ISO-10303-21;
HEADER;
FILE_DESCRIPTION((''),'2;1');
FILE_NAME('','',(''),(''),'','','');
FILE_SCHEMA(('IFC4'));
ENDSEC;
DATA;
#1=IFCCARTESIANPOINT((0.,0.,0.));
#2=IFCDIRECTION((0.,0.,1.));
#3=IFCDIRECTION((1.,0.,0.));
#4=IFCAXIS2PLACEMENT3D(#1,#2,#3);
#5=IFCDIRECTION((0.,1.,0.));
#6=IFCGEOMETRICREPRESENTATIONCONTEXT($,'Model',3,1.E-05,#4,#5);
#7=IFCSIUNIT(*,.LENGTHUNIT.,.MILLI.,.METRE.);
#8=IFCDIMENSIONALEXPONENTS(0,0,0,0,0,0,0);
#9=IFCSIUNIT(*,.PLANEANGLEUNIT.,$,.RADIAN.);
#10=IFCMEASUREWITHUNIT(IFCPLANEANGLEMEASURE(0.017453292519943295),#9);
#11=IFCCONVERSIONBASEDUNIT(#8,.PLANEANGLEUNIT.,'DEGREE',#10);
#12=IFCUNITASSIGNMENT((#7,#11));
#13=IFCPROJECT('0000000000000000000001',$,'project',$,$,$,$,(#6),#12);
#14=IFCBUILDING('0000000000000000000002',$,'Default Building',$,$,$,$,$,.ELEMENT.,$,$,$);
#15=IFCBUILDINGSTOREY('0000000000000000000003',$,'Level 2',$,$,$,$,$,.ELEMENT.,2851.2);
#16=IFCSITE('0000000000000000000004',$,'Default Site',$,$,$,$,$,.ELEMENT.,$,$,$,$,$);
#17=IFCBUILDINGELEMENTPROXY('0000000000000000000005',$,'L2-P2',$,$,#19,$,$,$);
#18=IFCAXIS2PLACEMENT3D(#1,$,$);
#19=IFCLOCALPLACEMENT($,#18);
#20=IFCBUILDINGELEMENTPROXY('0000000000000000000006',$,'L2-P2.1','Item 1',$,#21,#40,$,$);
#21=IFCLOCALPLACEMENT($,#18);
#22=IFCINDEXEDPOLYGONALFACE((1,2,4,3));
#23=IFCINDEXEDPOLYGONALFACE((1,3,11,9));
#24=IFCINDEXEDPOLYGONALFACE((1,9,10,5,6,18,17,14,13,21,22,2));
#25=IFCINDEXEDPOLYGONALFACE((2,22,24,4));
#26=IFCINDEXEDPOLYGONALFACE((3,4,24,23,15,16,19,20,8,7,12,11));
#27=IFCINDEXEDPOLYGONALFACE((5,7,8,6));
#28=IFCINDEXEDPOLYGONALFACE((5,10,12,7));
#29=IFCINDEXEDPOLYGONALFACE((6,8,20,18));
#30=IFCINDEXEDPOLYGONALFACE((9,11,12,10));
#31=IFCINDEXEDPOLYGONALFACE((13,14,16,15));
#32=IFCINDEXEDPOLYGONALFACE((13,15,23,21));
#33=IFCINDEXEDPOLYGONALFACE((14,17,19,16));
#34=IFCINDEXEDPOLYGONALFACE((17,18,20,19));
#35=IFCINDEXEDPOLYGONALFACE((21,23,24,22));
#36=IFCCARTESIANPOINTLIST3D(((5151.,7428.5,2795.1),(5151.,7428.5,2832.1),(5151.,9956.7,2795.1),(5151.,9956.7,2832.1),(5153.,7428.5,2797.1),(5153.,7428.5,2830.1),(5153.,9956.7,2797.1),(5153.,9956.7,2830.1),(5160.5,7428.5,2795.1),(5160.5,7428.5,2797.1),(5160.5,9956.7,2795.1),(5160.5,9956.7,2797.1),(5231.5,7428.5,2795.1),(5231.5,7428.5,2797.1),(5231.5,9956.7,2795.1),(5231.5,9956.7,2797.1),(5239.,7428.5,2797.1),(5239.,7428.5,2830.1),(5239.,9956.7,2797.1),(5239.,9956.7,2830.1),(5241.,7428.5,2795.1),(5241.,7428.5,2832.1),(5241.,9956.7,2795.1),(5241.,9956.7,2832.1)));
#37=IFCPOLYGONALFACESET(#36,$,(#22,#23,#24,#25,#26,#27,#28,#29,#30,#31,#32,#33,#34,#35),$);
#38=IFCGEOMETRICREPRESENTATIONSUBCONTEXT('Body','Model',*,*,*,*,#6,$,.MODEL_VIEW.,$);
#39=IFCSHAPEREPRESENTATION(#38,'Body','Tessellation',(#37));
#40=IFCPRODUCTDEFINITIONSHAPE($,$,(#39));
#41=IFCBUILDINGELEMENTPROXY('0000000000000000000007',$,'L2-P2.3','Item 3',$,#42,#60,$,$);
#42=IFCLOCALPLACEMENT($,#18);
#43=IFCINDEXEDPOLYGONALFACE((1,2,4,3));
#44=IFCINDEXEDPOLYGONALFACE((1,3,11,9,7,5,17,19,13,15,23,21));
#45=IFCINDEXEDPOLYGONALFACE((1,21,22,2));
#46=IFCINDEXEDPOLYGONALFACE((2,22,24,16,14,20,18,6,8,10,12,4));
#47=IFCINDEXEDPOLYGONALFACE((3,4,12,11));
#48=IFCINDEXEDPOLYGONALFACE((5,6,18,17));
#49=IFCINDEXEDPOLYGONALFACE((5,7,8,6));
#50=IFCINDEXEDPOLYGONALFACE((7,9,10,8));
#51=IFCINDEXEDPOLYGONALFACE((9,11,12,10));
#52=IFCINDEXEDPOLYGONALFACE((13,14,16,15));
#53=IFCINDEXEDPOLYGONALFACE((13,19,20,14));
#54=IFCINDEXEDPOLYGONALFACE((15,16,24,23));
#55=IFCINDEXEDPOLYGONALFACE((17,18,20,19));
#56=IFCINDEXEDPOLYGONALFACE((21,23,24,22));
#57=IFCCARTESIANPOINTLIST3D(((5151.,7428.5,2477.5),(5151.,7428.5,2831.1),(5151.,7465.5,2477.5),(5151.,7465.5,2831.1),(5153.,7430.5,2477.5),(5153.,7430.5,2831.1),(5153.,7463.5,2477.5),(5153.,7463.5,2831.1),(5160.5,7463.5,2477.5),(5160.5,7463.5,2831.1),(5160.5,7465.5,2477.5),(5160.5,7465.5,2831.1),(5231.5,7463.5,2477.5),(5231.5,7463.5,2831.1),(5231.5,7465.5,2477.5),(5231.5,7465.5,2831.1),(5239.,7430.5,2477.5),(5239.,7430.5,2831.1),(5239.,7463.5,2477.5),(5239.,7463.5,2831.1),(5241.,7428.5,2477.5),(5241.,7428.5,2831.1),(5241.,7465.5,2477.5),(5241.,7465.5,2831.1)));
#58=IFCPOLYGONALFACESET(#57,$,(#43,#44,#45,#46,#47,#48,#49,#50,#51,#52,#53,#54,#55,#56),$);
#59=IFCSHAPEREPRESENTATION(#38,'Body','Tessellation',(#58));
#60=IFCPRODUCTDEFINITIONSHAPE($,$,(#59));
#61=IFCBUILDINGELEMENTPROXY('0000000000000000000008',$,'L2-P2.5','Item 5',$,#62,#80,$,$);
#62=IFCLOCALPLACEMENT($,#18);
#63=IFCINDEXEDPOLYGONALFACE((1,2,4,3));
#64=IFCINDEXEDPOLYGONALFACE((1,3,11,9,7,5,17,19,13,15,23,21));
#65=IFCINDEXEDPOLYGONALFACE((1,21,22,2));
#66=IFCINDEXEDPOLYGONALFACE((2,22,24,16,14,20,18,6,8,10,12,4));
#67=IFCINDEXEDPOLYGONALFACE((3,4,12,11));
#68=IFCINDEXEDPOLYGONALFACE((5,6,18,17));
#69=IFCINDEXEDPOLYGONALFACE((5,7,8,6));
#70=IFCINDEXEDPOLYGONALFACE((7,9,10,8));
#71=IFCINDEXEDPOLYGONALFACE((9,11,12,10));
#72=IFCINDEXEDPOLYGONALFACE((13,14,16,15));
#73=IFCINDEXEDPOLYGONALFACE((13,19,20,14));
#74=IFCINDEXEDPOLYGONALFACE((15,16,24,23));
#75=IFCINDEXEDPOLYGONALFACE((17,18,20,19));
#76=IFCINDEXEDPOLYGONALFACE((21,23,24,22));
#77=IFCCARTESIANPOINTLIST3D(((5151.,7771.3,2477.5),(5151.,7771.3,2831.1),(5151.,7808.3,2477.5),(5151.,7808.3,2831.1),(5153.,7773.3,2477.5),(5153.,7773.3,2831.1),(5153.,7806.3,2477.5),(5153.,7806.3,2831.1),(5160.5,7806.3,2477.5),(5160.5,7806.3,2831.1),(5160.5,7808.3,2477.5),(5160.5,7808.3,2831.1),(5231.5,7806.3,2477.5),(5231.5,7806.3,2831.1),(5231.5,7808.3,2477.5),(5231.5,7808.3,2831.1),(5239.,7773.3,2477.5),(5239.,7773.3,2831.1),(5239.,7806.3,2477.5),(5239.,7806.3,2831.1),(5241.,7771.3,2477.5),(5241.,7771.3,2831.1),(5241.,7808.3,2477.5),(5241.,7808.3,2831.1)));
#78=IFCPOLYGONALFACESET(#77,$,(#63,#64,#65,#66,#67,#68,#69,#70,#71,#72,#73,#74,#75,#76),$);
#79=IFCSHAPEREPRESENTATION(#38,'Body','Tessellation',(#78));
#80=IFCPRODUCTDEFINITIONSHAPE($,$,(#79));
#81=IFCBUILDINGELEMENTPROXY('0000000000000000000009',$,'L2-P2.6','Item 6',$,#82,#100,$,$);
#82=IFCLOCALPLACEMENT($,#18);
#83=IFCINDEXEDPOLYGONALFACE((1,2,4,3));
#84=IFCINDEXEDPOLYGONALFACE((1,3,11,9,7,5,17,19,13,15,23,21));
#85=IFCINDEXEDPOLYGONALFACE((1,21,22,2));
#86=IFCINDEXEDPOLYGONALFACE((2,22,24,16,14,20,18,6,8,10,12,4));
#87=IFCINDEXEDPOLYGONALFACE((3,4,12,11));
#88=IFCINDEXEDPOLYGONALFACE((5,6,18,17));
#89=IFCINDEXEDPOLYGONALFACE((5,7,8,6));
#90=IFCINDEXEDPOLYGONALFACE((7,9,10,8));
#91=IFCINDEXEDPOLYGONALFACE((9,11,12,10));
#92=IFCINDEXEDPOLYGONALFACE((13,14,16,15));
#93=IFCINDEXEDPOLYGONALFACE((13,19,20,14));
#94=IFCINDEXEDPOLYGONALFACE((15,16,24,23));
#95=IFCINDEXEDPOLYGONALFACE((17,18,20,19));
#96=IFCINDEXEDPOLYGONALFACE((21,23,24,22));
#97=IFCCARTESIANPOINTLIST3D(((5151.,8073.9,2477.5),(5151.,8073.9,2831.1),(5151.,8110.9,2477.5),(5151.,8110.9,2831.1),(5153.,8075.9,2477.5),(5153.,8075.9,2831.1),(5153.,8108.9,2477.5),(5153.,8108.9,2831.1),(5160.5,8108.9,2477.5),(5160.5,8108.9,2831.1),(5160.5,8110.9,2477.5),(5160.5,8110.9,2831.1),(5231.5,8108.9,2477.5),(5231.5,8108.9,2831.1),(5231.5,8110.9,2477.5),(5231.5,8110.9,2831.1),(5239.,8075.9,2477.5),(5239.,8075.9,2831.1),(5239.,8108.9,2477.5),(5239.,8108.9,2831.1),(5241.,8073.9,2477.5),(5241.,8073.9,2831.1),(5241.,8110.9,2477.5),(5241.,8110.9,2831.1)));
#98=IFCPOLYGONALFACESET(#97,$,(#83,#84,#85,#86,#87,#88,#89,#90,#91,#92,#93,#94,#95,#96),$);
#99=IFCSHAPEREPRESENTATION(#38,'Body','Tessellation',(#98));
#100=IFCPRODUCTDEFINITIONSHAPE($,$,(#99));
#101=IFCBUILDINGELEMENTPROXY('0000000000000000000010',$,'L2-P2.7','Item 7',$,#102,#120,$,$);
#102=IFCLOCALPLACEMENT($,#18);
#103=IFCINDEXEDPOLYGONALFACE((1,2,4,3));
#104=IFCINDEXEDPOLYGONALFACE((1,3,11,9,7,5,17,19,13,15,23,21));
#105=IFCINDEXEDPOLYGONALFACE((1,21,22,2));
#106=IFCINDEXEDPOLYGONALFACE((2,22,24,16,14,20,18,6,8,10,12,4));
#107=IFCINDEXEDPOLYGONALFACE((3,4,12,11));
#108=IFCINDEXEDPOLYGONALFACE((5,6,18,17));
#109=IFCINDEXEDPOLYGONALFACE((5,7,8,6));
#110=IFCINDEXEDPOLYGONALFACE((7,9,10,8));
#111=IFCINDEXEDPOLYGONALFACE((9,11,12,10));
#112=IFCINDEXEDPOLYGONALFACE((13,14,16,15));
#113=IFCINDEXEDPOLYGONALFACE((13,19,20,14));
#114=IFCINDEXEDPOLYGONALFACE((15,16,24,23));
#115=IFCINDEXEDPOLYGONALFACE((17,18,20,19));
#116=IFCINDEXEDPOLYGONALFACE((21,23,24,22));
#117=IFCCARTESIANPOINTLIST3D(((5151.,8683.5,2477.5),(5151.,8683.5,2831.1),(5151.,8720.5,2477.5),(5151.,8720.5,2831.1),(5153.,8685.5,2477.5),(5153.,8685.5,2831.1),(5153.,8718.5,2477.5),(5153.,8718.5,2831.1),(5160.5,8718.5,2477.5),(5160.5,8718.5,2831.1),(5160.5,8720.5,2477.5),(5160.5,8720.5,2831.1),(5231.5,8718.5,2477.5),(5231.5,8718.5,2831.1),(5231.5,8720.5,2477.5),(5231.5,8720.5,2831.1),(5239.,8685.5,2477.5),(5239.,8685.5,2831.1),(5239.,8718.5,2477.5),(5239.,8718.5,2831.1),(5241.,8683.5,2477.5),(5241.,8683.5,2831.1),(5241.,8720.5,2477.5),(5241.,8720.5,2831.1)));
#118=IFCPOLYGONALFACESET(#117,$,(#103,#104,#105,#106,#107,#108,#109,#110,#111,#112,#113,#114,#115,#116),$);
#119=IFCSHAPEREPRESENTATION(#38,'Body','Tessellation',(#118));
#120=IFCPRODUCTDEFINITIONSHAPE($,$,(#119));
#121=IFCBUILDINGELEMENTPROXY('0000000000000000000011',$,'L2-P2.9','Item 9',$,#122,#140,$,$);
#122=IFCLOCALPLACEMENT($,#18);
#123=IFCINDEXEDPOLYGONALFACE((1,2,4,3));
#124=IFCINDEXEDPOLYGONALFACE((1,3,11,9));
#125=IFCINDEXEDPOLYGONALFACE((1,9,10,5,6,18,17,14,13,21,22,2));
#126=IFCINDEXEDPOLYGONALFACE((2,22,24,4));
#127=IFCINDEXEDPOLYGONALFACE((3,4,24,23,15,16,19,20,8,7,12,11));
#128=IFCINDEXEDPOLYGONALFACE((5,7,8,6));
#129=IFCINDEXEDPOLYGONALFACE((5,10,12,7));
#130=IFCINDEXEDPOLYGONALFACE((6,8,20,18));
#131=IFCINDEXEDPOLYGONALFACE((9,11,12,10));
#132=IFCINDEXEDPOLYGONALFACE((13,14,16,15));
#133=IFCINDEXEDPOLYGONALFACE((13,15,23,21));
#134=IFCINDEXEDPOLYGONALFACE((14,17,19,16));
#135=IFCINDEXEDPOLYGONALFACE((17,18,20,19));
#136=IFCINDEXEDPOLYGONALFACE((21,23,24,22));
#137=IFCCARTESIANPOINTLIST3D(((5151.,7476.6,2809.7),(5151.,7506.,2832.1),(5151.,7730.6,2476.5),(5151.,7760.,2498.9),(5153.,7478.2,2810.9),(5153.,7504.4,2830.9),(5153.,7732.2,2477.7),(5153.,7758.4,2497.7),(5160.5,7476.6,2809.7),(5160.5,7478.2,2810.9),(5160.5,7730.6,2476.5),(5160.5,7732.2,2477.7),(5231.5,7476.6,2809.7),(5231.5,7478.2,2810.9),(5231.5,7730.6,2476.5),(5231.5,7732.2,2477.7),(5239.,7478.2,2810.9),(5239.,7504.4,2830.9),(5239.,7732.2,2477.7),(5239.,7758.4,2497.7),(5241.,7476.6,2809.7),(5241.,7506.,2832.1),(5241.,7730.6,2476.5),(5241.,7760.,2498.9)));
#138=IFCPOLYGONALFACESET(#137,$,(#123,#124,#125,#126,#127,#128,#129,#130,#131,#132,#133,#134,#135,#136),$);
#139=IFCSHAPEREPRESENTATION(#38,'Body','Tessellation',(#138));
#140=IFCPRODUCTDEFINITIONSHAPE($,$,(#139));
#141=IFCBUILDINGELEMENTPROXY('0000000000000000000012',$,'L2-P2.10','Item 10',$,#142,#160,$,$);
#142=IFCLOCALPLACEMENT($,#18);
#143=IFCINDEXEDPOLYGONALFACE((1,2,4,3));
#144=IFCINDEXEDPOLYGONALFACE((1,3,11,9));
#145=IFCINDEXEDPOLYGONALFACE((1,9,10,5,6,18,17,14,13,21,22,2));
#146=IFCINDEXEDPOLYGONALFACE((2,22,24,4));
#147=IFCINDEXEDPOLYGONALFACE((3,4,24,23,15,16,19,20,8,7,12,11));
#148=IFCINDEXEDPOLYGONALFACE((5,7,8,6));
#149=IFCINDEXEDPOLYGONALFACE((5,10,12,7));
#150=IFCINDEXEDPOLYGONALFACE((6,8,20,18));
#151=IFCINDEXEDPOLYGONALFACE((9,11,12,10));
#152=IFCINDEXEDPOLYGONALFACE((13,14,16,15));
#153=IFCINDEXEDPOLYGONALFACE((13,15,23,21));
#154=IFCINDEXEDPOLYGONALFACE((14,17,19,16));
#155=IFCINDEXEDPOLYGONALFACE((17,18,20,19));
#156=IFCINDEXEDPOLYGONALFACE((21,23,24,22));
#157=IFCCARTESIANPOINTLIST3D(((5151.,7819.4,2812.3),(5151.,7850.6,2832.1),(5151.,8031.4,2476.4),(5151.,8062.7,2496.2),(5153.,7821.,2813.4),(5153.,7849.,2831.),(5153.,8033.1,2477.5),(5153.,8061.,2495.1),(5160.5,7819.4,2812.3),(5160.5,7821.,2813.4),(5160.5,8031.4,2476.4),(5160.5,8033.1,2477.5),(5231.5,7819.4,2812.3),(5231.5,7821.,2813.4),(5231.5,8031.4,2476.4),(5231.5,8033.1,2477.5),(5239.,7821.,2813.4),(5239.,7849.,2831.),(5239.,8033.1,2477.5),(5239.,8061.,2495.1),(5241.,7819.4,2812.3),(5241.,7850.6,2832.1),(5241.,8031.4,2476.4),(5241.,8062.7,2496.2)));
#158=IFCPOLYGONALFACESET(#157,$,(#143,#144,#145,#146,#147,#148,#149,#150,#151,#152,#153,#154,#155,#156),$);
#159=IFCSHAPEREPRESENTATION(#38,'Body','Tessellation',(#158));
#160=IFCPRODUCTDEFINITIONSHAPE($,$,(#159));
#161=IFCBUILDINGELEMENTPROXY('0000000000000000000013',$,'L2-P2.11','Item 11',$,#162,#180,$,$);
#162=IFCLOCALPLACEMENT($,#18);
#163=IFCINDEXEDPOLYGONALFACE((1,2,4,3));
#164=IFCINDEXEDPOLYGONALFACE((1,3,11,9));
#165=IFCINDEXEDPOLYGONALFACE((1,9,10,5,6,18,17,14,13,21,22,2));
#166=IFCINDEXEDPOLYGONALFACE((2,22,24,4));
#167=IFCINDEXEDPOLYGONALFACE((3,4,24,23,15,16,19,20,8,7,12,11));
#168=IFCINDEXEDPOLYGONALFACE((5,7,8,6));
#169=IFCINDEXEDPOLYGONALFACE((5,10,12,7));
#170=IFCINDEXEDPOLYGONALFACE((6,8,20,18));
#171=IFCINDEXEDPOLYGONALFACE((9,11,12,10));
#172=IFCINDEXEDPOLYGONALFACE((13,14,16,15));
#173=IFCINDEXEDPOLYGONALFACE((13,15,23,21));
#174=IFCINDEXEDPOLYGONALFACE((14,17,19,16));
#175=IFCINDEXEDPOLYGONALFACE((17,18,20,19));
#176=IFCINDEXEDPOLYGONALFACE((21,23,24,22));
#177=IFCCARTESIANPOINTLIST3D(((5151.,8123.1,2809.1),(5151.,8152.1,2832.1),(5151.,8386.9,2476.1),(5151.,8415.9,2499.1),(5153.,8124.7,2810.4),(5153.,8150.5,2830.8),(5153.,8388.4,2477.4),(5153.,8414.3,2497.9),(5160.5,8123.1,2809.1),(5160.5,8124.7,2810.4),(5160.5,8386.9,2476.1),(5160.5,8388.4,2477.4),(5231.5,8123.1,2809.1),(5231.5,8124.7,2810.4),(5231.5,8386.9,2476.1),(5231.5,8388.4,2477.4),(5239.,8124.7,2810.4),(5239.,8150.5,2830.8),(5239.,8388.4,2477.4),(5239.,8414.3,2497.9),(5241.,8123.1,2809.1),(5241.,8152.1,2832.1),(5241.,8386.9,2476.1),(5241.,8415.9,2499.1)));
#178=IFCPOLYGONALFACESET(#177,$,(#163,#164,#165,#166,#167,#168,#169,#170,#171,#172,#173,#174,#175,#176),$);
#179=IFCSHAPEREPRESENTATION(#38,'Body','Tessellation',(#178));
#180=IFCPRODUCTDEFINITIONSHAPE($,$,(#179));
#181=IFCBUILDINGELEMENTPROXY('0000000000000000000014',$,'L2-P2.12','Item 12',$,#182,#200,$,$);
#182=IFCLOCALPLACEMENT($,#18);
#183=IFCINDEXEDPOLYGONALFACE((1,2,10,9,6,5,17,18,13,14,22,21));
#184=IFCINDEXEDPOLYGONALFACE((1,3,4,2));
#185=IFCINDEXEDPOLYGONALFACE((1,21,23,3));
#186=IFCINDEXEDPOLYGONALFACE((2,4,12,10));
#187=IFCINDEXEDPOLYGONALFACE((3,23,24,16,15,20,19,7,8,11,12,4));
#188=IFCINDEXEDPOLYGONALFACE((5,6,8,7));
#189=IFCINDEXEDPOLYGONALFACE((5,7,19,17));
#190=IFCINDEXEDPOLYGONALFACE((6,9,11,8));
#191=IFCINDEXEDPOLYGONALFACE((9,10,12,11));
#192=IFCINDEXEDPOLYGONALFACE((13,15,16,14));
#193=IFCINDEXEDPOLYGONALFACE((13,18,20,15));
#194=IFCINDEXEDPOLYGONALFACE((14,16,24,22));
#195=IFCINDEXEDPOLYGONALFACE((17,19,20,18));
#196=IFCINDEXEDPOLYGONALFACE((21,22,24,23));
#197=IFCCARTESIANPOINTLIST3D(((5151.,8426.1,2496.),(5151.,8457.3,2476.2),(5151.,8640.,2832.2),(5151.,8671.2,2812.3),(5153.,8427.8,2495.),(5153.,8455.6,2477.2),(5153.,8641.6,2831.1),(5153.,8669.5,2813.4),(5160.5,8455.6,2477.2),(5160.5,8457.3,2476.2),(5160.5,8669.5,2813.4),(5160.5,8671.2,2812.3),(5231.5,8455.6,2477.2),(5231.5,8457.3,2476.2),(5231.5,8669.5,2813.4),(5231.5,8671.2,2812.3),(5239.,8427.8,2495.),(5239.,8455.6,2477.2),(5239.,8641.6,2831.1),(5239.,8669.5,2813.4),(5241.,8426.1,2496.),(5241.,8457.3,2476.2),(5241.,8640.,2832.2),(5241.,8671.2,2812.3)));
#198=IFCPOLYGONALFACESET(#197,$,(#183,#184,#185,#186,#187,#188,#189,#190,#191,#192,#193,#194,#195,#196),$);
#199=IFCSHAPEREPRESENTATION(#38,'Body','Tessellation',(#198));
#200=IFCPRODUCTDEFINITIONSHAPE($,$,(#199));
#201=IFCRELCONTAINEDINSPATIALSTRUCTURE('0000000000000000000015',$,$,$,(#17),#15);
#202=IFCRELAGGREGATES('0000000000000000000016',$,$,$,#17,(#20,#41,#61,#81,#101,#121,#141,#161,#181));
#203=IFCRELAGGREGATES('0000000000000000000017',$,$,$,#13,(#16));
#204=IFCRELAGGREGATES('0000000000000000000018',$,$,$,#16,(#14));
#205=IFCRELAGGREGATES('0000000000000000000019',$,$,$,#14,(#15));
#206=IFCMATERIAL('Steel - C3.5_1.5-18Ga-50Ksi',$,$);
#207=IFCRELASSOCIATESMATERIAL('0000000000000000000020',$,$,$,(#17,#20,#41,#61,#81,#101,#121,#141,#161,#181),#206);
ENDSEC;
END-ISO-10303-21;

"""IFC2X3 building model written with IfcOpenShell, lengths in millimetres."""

from ifc_helpers import new_model, entity, si_unit, converted_unit, direction, frame, origin, origin_with_axes, origin_2d_with_axis, place, context, subcontext, project, spatial, c_section, extrude, material, element, aggregate, save


model = new_model("IFC2X3")

# Units and contexts
model_context = context("Model", 3, precision=1e-05, world=origin_with_axes(), true_north=direction((0.0, 1.0, 0.0)))
body_context = subcontext(model_context, "Body", "Model", "MODEL_VIEW")
ifc_project = project(units=[si_unit("LENGTHUNIT", "METRE", prefix="MILLI"), converted_unit("PLANEANGLEUNIT", "DEGREE", entity("IfcPlaneAngleMeasure", 0.017453292519943295), si_unit("PLANEANGLEUNIT", "RADIAN"), dimensions=[0, 0, 0, 0, 0, 0, 0])], contexts=[model_context])

# Site, building, storey
site = spatial("IfcSite", under=ifc_project, Name="Default Site", CompositionType="ELEMENT")
building = spatial("IfcBuilding", under=site, Name="Default Building", CompositionType="ELEMENT")
storey = spatial("IfcBuildingStorey", under=building, Name="Level 2", CompositionType="ELEMENT", Elevation=2851.2)

# Building element proxies
ifc_material_1 = material(Name="Steel - C3.5_1.5-18Ga-50Ksi")
proxy_1 = element("IfcBuildingElementProxy", 1, inside=storey, material=ifc_material_1, Name="L2-P2")
proxy_2_placement = place(None, frame((5196.0, 7428.5, 2813.6), z_axis=(0.0, 1.0, 0.0), x_axis=(0.0, 0.0, -37.0)))
proxy_2 = element("IfcBuildingElementProxy", 2, at=proxy_2_placement, material=ifc_material_1, Name="L2-P2.1", Description="Item 1", context=body_context, shape_type="SweptSolid", body=[
    extrude(c_section(Depth=90.0, Width=37.0, WallThickness=2.0, Girth=9.5, at=origin_2d_with_axis()), origin(), (0.0, 0.0, 1.0), 2528.2),
])
proxy_3_placement = place(None, frame((5196.0, 7447.0, 2477.5), z_axis=(0.0, 0.0, 1.0), x_axis=(0.0, 37.0, 0.0)))
proxy_3 = element("IfcBuildingElementProxy", 3, at=proxy_3_placement, material=ifc_material_1, Name="L2-P2.3", Description="Item 3", context=body_context, shape_type="SweptSolid", body=[
    extrude(c_section(Depth=90.0, Width=37.0, WallThickness=2.0, Girth=9.5, at=origin_2d_with_axis()), origin(), (0.0, 0.0, 1.0), 353.6),
])
proxy_4_placement = place(None, frame((5196.0, 7789.8, 2477.5), z_axis=(0.0, 0.0, 1.0), x_axis=(0.0, 37.0, 0.0)))
proxy_4 = element("IfcBuildingElementProxy", 4, at=proxy_4_placement, material=ifc_material_1, Name="L2-P2.5", Description="Item 5", context=body_context, shape_type="SweptSolid", body=[
    extrude(c_section(Depth=90.0, Width=37.0, WallThickness=2.0, Girth=9.5, at=origin_2d_with_axis()), origin(), (0.0, 0.0, 1.0), 353.6),
])
proxy_5_placement = place(None, frame((5196.0, 8092.4, 2477.5), z_axis=(0.0, 0.0, 1.0), x_axis=(0.0, 37.0, 0.0)))
proxy_5 = element("IfcBuildingElementProxy", 5, at=proxy_5_placement, material=ifc_material_1, Name="L2-P2.6", Description="Item 6", context=body_context, shape_type="SweptSolid", body=[
    extrude(c_section(Depth=90.0, Width=37.0, WallThickness=2.0, Girth=9.5, at=origin_2d_with_axis()), origin(), (0.0, 0.0, 1.0), 353.6),
])
proxy_6_placement = place(None, frame((5196.0, 8702.0, 2477.5), z_axis=(0.0, 0.0, 1.0), x_axis=(0.0, 37.0, 0.0)))
proxy_6 = element("IfcBuildingElementProxy", 6, at=proxy_6_placement, material=ifc_material_1, Name="L2-P2.7", Description="Item 7", context=body_context, shape_type="SweptSolid", body=[
    extrude(c_section(Depth=90.0, Width=37.0, WallThickness=2.0, Girth=9.5, at=origin_2d_with_axis()), origin(), (0.0, 0.0, 1.0), 353.6),
])
proxy_7_placement = place(None, frame((5196.0, 7491.3, 2820.9), z_axis=(0.0, 0.606, -0.795), x_axis=(0.0, -29.421, -22.437)))
proxy_7 = element("IfcBuildingElementProxy", 7, at=proxy_7_placement, material=ifc_material_1, Name="L2-P2.9", Description="Item 9", context=body_context, shape_type="SweptSolid", body=[
    extrude(c_section(Depth=90.0, Width=37.0, WallThickness=2.0, Girth=9.5, at=origin_2d_with_axis()), origin(), (0.0, 0.0, 1.0), 419.0),
])
proxy_8_placement = place(None, frame((5196.0, 7835.0, 2822.2), z_axis=(0.0, 0.534, -0.846), x_axis=(0.0, -31.287, -19.752)))
proxy_8 = element("IfcBuildingElementProxy", 8, at=proxy_8_placement, material=ifc_material_1, Name="L2-P2.10", Description="Item 10", context=body_context, shape_type="SweptSolid", body=[
    extrude(c_section(Depth=90.0, Width=37.0, WallThickness=2.0, Girth=9.5, at=origin_2d_with_axis()), origin(), (0.0, 0.0, 1.0), 397.2),
])
proxy_9_placement = place(None, frame((5196.0, 8137.6, 2820.6), z_axis=(0.0, 0.621, -0.784), x_axis=(0.0, -28.995, -22.984)))
proxy_9 = element("IfcBuildingElementProxy", 9, at=proxy_9_placement, material=ifc_material_1, Name="L2-P2.11", Description="Item 11", context=body_context, shape_type="SweptSolid", body=[
    extrude(c_section(Depth=90.0, Width=37.0, WallThickness=2.0, Girth=9.5, at=origin_2d_with_axis()), origin(), (0.0, 0.0, 1.0), 424.8),
])
proxy_10_placement = place(None, frame((5196.0, 8441.7, 2486.1), z_axis=(0.0, 0.537, 0.844), x_axis=(0.0, 31.21, -19.873)))
proxy_10 = element("IfcBuildingElementProxy", 10, at=proxy_10_placement, material=ifc_material_1, Name="L2-P2.12", Description="Item 12", context=body_context, shape_type="SweptSolid", body=[
    extrude(c_section(Depth=90.0, Width=37.0, WallThickness=2.0, Girth=9.5, at=origin_2d_with_axis()), origin(), (0.0, 0.0, 1.0), 398.4),
])
aggregate(proxy_1, [proxy_2, proxy_3, proxy_4, proxy_5, proxy_6, proxy_7, proxy_8, proxy_9, proxy_10])

save(model, "model.ifc")
